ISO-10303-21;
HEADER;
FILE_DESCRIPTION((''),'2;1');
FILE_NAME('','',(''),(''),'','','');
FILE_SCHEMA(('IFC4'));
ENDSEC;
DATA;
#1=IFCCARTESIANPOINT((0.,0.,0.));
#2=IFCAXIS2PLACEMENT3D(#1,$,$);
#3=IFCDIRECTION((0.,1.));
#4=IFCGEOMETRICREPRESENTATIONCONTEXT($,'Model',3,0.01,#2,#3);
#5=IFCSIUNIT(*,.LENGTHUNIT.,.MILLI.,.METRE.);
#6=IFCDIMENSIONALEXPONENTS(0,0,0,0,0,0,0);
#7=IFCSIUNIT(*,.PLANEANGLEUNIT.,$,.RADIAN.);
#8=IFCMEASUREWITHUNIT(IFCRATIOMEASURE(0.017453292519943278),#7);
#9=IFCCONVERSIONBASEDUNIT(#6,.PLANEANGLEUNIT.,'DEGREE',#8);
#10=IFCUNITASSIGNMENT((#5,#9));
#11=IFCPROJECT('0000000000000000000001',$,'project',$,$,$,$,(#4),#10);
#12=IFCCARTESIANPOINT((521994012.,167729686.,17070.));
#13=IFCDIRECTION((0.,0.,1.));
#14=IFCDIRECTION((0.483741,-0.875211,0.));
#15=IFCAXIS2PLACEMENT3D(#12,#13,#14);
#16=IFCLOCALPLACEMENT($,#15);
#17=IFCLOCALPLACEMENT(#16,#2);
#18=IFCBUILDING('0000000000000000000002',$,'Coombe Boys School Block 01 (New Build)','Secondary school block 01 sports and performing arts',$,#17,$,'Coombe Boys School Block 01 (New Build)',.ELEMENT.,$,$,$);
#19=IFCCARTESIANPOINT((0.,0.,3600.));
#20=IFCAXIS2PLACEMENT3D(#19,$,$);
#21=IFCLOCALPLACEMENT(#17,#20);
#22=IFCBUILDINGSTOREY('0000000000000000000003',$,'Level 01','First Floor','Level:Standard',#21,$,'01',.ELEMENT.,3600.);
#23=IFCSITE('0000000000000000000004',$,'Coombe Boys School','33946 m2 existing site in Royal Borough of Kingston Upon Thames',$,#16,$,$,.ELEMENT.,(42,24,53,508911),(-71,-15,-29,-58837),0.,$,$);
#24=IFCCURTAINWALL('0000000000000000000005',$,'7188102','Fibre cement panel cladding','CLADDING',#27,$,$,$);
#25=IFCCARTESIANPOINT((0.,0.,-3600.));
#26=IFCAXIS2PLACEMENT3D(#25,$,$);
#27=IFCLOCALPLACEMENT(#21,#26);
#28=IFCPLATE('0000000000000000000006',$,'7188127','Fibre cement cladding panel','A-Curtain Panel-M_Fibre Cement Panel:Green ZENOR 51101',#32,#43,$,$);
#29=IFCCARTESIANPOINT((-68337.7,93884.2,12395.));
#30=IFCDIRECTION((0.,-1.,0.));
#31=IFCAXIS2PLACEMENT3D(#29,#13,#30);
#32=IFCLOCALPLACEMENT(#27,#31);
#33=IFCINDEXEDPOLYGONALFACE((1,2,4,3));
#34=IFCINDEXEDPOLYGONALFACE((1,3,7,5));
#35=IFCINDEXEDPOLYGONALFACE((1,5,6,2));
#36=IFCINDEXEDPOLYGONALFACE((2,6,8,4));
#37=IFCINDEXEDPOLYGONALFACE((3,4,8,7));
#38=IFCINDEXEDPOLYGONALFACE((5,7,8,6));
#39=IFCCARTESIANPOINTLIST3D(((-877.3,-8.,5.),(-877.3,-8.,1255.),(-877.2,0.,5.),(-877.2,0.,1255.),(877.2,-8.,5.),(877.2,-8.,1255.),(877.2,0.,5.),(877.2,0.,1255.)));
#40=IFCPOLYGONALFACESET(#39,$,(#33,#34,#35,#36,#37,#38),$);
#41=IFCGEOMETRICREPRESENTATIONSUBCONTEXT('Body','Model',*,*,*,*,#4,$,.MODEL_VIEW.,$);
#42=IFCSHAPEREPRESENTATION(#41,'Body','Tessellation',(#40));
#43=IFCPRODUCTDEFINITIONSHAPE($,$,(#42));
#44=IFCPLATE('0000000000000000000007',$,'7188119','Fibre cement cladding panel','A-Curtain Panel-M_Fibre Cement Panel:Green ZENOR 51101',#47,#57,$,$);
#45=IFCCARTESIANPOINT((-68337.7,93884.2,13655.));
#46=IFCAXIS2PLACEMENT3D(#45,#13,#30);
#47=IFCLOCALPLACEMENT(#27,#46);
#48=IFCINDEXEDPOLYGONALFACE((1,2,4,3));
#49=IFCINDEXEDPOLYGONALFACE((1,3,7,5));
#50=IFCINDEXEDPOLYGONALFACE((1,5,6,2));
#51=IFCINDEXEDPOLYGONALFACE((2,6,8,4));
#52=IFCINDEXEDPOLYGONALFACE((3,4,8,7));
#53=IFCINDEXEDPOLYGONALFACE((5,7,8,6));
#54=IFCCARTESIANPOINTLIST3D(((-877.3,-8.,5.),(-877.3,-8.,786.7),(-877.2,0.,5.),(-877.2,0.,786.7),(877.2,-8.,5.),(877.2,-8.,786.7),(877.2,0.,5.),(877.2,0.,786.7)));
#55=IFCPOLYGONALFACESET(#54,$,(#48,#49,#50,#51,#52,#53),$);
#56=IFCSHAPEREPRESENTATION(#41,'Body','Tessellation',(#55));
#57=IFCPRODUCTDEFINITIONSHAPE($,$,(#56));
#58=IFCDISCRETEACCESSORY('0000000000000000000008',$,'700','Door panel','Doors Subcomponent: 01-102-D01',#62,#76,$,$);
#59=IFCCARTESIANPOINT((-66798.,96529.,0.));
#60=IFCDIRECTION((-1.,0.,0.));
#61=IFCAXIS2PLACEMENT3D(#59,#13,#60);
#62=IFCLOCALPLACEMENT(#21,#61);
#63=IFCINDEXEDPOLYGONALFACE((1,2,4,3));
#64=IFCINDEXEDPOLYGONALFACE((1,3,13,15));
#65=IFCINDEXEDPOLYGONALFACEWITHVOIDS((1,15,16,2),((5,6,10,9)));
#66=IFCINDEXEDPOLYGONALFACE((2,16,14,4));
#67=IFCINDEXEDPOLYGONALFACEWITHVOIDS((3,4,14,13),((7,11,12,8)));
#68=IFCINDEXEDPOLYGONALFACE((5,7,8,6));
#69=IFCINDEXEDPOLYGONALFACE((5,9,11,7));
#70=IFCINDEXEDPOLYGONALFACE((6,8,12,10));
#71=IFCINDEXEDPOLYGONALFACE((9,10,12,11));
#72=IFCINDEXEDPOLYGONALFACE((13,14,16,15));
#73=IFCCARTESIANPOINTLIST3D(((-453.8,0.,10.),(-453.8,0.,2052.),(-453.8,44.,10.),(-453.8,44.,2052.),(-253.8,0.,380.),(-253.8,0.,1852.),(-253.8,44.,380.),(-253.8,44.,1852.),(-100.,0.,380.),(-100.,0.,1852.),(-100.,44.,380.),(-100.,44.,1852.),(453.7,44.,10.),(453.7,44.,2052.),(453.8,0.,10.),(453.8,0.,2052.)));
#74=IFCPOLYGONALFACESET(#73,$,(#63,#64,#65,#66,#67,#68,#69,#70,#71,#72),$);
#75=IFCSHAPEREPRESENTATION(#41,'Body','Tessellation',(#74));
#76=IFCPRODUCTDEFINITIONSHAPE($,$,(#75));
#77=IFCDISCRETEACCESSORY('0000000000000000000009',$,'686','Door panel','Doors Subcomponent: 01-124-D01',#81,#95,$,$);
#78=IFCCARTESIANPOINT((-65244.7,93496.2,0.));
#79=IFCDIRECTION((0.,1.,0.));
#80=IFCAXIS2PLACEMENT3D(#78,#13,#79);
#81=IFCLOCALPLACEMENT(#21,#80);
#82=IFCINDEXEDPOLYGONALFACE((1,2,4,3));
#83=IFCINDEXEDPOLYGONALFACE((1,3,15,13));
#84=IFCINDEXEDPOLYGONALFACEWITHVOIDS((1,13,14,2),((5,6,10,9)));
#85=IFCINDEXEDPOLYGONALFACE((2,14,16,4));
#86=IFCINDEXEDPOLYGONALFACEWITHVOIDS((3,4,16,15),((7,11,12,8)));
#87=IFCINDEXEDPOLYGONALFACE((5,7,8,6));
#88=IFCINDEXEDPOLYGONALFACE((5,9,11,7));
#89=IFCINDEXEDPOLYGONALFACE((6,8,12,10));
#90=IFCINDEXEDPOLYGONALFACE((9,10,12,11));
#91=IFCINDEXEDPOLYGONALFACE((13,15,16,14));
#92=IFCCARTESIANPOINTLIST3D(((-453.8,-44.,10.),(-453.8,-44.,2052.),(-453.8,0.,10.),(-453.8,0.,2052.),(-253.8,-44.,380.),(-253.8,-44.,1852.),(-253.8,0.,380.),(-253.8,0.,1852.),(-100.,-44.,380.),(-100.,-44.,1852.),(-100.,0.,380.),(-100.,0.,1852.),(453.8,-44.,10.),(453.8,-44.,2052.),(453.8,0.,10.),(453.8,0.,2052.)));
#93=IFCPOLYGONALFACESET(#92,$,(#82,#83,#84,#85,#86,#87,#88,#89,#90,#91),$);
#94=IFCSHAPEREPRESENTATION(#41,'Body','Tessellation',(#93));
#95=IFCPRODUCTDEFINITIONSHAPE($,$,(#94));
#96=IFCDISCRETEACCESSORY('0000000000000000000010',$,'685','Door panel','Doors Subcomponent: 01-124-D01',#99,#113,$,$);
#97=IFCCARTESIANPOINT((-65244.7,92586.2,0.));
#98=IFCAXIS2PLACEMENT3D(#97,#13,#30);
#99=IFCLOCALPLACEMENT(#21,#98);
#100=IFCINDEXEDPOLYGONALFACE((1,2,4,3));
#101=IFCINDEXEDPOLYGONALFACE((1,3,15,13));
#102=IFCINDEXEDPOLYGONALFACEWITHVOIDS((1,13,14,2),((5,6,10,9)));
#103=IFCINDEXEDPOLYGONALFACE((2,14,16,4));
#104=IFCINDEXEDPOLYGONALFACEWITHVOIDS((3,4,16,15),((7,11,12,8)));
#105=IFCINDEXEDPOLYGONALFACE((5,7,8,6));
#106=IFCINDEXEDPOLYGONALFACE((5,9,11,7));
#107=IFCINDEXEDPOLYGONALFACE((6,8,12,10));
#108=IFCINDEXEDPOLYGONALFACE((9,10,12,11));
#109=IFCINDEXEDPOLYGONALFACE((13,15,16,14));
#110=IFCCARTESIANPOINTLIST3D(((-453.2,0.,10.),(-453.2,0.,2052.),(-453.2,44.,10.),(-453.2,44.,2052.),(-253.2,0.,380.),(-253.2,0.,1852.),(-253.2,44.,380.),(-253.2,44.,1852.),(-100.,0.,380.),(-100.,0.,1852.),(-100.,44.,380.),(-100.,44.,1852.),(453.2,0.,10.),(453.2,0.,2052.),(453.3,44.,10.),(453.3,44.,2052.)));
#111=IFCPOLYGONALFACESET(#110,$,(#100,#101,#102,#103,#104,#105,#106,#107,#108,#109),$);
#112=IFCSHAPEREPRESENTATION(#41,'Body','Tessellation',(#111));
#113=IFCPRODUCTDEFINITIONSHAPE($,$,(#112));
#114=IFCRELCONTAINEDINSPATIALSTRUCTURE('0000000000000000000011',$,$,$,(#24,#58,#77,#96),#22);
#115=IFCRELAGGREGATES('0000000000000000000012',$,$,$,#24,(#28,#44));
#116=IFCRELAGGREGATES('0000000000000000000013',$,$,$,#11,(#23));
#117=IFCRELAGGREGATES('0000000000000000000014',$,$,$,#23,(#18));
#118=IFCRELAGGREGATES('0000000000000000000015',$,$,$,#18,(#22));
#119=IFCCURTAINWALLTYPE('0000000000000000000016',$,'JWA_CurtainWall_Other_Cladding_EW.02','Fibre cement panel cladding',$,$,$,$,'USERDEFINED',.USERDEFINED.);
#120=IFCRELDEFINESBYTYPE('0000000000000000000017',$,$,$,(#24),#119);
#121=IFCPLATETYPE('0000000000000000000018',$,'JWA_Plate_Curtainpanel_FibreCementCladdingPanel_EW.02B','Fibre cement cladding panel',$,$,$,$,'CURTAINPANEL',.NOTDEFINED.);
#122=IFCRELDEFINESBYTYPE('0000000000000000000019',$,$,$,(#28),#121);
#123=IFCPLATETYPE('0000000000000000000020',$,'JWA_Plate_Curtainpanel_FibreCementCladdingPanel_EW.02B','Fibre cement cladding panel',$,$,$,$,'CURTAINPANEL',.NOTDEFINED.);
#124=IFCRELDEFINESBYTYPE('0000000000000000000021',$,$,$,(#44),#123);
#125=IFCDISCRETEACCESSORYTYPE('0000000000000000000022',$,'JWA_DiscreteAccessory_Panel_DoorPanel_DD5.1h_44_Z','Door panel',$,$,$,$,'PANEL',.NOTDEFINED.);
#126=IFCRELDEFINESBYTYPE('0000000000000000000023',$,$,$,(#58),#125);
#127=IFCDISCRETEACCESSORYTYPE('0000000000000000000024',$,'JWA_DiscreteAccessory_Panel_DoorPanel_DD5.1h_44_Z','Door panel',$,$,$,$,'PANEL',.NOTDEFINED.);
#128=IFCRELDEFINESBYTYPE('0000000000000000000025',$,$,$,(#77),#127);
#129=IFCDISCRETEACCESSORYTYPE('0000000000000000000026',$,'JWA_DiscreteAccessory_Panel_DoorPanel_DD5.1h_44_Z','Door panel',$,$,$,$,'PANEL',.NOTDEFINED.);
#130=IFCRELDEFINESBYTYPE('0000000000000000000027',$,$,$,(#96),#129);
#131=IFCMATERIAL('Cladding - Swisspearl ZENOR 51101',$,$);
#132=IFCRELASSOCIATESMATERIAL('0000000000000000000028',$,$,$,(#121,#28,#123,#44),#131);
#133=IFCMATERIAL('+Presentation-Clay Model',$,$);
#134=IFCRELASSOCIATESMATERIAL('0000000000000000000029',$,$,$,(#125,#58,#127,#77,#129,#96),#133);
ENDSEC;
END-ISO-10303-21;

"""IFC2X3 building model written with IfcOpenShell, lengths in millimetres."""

from ifc_helpers import new_model, entity, si_unit, converted_unit, direction, frame, origin, origin_2d_with_axis, place, context, subcontext, project, spatial, polyline, rectangle, outline, extrude, source, transform, mapped, material, type_object, type_shapes, element, aggregate, save


model = new_model("IFC2X3")

# Units and contexts
model_context = context("Model", 3, precision=0.01, world=origin(), true_north=direction((0.0, 1.0)))
body_context = subcontext(model_context, "Body", "Model", "MODEL_VIEW")
ifc_project = project(units=[si_unit("LENGTHUNIT", "METRE", prefix="MILLI"), converted_unit("PLANEANGLEUNIT", "DEGREE", entity("IfcRatioMeasure", 0.017453292519943278), si_unit("PLANEANGLEUNIT", "RADIAN"), dimensions=[0, 0, 0, 0, 0, 0, 0])], contexts=[model_context])

# Site, building, storey
site_placement = place(None, frame((521994012.0, 167729686.0, 17070.0), z_axis=(0.0, 0.0, 1.0), x_axis=(0.483741, -0.875211, 0.0)))
site = spatial("IfcSite", under=ifc_project, at=site_placement, Name="Coombe Boys School", Description="33946 m2 existing site in Royal Borough of Kingston Upon Thames", CompositionType="ELEMENT", RefLatitude=(42, 24, 53, 508911), RefLongitude=(-71, -15, -29, -58837), RefElevation=0.0)
building_placement = place(site_placement, origin())
building = spatial("IfcBuilding", under=site, at=building_placement, Name="Coombe Boys School Block 01 (New Build)", Description="Secondary school block 01 sports and performing arts", LongName="Coombe Boys School Block 01 (New Build)", CompositionType="ELEMENT")
storey_placement = place(building_placement, frame((0.0, 0.0, 3600.0)))
storey = spatial("IfcBuildingStorey", under=building, at=storey_placement, Name="Level 01", Description="First Floor", ObjectType="Level:Standard", LongName="01", CompositionType="ELEMENT", Elevation=3600.0)

# Curtain wall, plates
curtain_wall_type = type_object("IfcCurtainWallType", Name="JWA_CurtainWall_Other_Cladding_EW.02", Description="Fibre cement panel cladding", ElementType="USERDEFINED", PredefinedType="USERDEFINED")
curtain_wall_placement = place(storey_placement, frame((0.0, 0.0, -3600.0)))
curtain_wall = element("IfcCurtainWall", 1, at=curtain_wall_placement, inside=storey, type_object=curtain_wall_type, Name="7188102", Description="Fibre cement panel cladding", ObjectType="CLADDING")
ifc_material_1 = material(Name="Cladding - Swisspearl ZENOR 51101")
plate_type_1 = type_object("IfcPlateType", Name="JWA_Plate_Curtainpanel_FibreCementCladdingPanel_EW.02B", Description="Fibre cement cladding panel", ElementType="CURTAINPANEL", PredefinedType="NOTDEFINED", material=ifc_material_1)
shared_shape_1 = source(origin(), body_context, "Body", "SweptSolid", [
    extrude(rectangle(XDim=1754.5, YDim=8.0, at=origin_2d_with_axis()), frame((0.0, -4.0, 5.0), z_axis=(0.0, 0.0, 1.0), x_axis=(-1.0, 0.0, 0.0)), (0.0, 0.0, 1.0), 1250.0),
])
type_shapes(plate_type_1, [shared_shape_1])
plate_1_placement = place(curtain_wall_placement, frame((-68337.7, 93884.2, 12395.0), z_axis=(0.0, 0.0, 1.0), x_axis=(0.0, -1.0, 0.0)))
plate_1 = element("IfcPlate", 2, at=plate_1_placement, type_object=plate_type_1, material=ifc_material_1, Name="7188127", Description="Fibre cement cladding panel", ObjectType="A-Curtain Panel-M_Fibre Cement Panel:Green ZENOR 51101", context=body_context, shape_type="MappedRepresentation", body=[
    mapped(shared_shape_1, transform((0.0, 0.0, 0.0), scale=1.0)),
])
plate_type_2 = type_object("IfcPlateType", Name="JWA_Plate_Curtainpanel_FibreCementCladdingPanel_EW.02B", Description="Fibre cement cladding panel", ElementType="CURTAINPANEL", PredefinedType="NOTDEFINED", material=ifc_material_1)
shared_shape_2 = source(origin(), body_context, "Body", "SweptSolid", [
    extrude(rectangle(XDim=1754.5, YDim=8.0, at=origin_2d_with_axis()), frame((0.0, -4.0, 5.0), z_axis=(0.0, 0.0, 1.0), x_axis=(-1.0, 0.0, 0.0)), (0.0, 0.0, 1.0), 781.7),
])
type_shapes(plate_type_2, [shared_shape_2])
plate_2_placement = place(curtain_wall_placement, frame((-68337.7, 93884.2, 13655.0), z_axis=(0.0, 0.0, 1.0), x_axis=(0.0, -1.0, 0.0)))
plate_2 = element("IfcPlate", 3, at=plate_2_placement, type_object=plate_type_2, material=ifc_material_1, Name="7188119", Description="Fibre cement cladding panel", ObjectType="A-Curtain Panel-M_Fibre Cement Panel:Green ZENOR 51101", context=body_context, shape_type="MappedRepresentation", body=[
    mapped(shared_shape_2, transform((0.0, 0.0, 0.0), scale=1.0)),
])
aggregate(curtain_wall, [plate_1, plate_2])

# Discrete accessory
ifc_material_2 = material(Name="+Presentation-Clay Model")
discrete_accessory_type_1 = type_object("IfcDiscreteAccessoryType", Name="JWA_DiscreteAccessory_Panel_DoorPanel_DD5.1h_44_Z", Description="Door panel", ElementType="PANEL", material=ifc_material_2)
shared_shape_3 = source(origin(), body_context, "Body", "SweptSolid", [
    extrude(outline(polyline([(-1021.0, -453.7), (1021.0, -453.7), (1021.0, 453.7), (-1021.0, 453.7), (-1021.0, -453.7)]), holes=[polyline([(-821.0, 100.0), (-821.0, 253.7), (651.0, 253.7), (651.0, 100.0), (-821.0, 100.0)])]), frame((0.0, 0.0, 1031.0), z_axis=(0.0, 1.0, 0.0), x_axis=(0.0, 0.0, -1.0)), (0.0, 0.0, 1.0), 44.0),
])
type_shapes(discrete_accessory_type_1, [shared_shape_3])
discrete_accessory_1_placement = place(storey_placement, frame((-66798.0, 96529.0, 0.0), z_axis=(0.0, 0.0, 1.0), x_axis=(-1.0, 0.0, 0.0)))
element("IfcDiscreteAccessory", 4, at=discrete_accessory_1_placement, inside=storey, type_object=discrete_accessory_type_1, material=ifc_material_2, Name="700", Description="Door panel", ObjectType="Doors Subcomponent: 01-102-D01", context=body_context, shape_type="MappedRepresentation", body=[
    mapped(shared_shape_3, transform((0.0, 0.0, 0.0), scale=1.0)),
])

# Discrete accessories
discrete_accessory_type_2 = type_object("IfcDiscreteAccessoryType", Name="JWA_DiscreteAccessory_Panel_DoorPanel_DD5.1h_44_Z", Description="Door panel", ElementType="PANEL", material=ifc_material_2)
shared_shape_4 = source(origin(), body_context, "Body", "SweptSolid", [
    extrude(outline(polyline([(-1021.0, -453.7), (1021.0, -453.7), (1021.0, 453.7), (-1021.0, 453.7), (-1021.0, -453.7)]), holes=[polyline([(-821.0, 100.0), (-821.0, 253.7), (651.0, 253.7), (651.0, 100.0), (-821.0, 100.0)])]), frame((0.0, -44.0, 1031.0), z_axis=(0.0, 1.0, 0.0), x_axis=(0.0, 0.0, -1.0)), (0.0, 0.0, 1.0), 44.0),
])
type_shapes(discrete_accessory_type_2, [shared_shape_4])
discrete_accessory_2_placement = place(storey_placement, frame((-65244.7, 93496.2, 0.0), z_axis=(0.0, 0.0, 1.0), x_axis=(0.0, 1.0, 0.0)))
element("IfcDiscreteAccessory", 5, at=discrete_accessory_2_placement, inside=storey, type_object=discrete_accessory_type_2, material=ifc_material_2, Name="686", Description="Door panel", ObjectType="Doors Subcomponent: 01-124-D01", context=body_context, shape_type="MappedRepresentation", body=[
    mapped(shared_shape_4, transform((0.0, 0.0, 0.0), scale=1.0)),
])
discrete_accessory_type_3 = type_object("IfcDiscreteAccessoryType", Name="JWA_DiscreteAccessory_Panel_DoorPanel_DD5.1h_44_Z", Description="Door panel", ElementType="PANEL", material=ifc_material_2)
shared_shape_5 = source(origin(), body_context, "Body", "SweptSolid", [
    extrude(outline(polyline([(-1021.0, -453.3), (1021.0, -453.3), (1021.0, 453.3), (-1021.0, 453.3), (-1021.0, -453.3)]), holes=[polyline([(-821.0, 100.0), (-821.0, 253.2), (651.0, 253.2), (651.0, 100.0), (-821.0, 100.0)])]), frame((0.0, 0.0, 1031.0), z_axis=(0.0, 1.0, 0.0), x_axis=(0.0, 0.0, -1.0)), (0.0, 0.0, 1.0), 44.0),
])
type_shapes(discrete_accessory_type_3, [shared_shape_5])
discrete_accessory_3_placement = place(storey_placement, frame((-65244.7, 92586.2, 0.0), z_axis=(0.0, 0.0, 1.0), x_axis=(0.0, -1.0, 0.0)))
element("IfcDiscreteAccessory", 6, at=discrete_accessory_3_placement, inside=storey, type_object=discrete_accessory_type_3, material=ifc_material_2, Name="685", Description="Door panel", ObjectType="Doors Subcomponent: 01-124-D01", context=body_context, shape_type="MappedRepresentation", body=[
    mapped(shared_shape_5, transform((0.0, 0.0, 0.0), scale=1.0)),
])

save(model, "model.ifc")
